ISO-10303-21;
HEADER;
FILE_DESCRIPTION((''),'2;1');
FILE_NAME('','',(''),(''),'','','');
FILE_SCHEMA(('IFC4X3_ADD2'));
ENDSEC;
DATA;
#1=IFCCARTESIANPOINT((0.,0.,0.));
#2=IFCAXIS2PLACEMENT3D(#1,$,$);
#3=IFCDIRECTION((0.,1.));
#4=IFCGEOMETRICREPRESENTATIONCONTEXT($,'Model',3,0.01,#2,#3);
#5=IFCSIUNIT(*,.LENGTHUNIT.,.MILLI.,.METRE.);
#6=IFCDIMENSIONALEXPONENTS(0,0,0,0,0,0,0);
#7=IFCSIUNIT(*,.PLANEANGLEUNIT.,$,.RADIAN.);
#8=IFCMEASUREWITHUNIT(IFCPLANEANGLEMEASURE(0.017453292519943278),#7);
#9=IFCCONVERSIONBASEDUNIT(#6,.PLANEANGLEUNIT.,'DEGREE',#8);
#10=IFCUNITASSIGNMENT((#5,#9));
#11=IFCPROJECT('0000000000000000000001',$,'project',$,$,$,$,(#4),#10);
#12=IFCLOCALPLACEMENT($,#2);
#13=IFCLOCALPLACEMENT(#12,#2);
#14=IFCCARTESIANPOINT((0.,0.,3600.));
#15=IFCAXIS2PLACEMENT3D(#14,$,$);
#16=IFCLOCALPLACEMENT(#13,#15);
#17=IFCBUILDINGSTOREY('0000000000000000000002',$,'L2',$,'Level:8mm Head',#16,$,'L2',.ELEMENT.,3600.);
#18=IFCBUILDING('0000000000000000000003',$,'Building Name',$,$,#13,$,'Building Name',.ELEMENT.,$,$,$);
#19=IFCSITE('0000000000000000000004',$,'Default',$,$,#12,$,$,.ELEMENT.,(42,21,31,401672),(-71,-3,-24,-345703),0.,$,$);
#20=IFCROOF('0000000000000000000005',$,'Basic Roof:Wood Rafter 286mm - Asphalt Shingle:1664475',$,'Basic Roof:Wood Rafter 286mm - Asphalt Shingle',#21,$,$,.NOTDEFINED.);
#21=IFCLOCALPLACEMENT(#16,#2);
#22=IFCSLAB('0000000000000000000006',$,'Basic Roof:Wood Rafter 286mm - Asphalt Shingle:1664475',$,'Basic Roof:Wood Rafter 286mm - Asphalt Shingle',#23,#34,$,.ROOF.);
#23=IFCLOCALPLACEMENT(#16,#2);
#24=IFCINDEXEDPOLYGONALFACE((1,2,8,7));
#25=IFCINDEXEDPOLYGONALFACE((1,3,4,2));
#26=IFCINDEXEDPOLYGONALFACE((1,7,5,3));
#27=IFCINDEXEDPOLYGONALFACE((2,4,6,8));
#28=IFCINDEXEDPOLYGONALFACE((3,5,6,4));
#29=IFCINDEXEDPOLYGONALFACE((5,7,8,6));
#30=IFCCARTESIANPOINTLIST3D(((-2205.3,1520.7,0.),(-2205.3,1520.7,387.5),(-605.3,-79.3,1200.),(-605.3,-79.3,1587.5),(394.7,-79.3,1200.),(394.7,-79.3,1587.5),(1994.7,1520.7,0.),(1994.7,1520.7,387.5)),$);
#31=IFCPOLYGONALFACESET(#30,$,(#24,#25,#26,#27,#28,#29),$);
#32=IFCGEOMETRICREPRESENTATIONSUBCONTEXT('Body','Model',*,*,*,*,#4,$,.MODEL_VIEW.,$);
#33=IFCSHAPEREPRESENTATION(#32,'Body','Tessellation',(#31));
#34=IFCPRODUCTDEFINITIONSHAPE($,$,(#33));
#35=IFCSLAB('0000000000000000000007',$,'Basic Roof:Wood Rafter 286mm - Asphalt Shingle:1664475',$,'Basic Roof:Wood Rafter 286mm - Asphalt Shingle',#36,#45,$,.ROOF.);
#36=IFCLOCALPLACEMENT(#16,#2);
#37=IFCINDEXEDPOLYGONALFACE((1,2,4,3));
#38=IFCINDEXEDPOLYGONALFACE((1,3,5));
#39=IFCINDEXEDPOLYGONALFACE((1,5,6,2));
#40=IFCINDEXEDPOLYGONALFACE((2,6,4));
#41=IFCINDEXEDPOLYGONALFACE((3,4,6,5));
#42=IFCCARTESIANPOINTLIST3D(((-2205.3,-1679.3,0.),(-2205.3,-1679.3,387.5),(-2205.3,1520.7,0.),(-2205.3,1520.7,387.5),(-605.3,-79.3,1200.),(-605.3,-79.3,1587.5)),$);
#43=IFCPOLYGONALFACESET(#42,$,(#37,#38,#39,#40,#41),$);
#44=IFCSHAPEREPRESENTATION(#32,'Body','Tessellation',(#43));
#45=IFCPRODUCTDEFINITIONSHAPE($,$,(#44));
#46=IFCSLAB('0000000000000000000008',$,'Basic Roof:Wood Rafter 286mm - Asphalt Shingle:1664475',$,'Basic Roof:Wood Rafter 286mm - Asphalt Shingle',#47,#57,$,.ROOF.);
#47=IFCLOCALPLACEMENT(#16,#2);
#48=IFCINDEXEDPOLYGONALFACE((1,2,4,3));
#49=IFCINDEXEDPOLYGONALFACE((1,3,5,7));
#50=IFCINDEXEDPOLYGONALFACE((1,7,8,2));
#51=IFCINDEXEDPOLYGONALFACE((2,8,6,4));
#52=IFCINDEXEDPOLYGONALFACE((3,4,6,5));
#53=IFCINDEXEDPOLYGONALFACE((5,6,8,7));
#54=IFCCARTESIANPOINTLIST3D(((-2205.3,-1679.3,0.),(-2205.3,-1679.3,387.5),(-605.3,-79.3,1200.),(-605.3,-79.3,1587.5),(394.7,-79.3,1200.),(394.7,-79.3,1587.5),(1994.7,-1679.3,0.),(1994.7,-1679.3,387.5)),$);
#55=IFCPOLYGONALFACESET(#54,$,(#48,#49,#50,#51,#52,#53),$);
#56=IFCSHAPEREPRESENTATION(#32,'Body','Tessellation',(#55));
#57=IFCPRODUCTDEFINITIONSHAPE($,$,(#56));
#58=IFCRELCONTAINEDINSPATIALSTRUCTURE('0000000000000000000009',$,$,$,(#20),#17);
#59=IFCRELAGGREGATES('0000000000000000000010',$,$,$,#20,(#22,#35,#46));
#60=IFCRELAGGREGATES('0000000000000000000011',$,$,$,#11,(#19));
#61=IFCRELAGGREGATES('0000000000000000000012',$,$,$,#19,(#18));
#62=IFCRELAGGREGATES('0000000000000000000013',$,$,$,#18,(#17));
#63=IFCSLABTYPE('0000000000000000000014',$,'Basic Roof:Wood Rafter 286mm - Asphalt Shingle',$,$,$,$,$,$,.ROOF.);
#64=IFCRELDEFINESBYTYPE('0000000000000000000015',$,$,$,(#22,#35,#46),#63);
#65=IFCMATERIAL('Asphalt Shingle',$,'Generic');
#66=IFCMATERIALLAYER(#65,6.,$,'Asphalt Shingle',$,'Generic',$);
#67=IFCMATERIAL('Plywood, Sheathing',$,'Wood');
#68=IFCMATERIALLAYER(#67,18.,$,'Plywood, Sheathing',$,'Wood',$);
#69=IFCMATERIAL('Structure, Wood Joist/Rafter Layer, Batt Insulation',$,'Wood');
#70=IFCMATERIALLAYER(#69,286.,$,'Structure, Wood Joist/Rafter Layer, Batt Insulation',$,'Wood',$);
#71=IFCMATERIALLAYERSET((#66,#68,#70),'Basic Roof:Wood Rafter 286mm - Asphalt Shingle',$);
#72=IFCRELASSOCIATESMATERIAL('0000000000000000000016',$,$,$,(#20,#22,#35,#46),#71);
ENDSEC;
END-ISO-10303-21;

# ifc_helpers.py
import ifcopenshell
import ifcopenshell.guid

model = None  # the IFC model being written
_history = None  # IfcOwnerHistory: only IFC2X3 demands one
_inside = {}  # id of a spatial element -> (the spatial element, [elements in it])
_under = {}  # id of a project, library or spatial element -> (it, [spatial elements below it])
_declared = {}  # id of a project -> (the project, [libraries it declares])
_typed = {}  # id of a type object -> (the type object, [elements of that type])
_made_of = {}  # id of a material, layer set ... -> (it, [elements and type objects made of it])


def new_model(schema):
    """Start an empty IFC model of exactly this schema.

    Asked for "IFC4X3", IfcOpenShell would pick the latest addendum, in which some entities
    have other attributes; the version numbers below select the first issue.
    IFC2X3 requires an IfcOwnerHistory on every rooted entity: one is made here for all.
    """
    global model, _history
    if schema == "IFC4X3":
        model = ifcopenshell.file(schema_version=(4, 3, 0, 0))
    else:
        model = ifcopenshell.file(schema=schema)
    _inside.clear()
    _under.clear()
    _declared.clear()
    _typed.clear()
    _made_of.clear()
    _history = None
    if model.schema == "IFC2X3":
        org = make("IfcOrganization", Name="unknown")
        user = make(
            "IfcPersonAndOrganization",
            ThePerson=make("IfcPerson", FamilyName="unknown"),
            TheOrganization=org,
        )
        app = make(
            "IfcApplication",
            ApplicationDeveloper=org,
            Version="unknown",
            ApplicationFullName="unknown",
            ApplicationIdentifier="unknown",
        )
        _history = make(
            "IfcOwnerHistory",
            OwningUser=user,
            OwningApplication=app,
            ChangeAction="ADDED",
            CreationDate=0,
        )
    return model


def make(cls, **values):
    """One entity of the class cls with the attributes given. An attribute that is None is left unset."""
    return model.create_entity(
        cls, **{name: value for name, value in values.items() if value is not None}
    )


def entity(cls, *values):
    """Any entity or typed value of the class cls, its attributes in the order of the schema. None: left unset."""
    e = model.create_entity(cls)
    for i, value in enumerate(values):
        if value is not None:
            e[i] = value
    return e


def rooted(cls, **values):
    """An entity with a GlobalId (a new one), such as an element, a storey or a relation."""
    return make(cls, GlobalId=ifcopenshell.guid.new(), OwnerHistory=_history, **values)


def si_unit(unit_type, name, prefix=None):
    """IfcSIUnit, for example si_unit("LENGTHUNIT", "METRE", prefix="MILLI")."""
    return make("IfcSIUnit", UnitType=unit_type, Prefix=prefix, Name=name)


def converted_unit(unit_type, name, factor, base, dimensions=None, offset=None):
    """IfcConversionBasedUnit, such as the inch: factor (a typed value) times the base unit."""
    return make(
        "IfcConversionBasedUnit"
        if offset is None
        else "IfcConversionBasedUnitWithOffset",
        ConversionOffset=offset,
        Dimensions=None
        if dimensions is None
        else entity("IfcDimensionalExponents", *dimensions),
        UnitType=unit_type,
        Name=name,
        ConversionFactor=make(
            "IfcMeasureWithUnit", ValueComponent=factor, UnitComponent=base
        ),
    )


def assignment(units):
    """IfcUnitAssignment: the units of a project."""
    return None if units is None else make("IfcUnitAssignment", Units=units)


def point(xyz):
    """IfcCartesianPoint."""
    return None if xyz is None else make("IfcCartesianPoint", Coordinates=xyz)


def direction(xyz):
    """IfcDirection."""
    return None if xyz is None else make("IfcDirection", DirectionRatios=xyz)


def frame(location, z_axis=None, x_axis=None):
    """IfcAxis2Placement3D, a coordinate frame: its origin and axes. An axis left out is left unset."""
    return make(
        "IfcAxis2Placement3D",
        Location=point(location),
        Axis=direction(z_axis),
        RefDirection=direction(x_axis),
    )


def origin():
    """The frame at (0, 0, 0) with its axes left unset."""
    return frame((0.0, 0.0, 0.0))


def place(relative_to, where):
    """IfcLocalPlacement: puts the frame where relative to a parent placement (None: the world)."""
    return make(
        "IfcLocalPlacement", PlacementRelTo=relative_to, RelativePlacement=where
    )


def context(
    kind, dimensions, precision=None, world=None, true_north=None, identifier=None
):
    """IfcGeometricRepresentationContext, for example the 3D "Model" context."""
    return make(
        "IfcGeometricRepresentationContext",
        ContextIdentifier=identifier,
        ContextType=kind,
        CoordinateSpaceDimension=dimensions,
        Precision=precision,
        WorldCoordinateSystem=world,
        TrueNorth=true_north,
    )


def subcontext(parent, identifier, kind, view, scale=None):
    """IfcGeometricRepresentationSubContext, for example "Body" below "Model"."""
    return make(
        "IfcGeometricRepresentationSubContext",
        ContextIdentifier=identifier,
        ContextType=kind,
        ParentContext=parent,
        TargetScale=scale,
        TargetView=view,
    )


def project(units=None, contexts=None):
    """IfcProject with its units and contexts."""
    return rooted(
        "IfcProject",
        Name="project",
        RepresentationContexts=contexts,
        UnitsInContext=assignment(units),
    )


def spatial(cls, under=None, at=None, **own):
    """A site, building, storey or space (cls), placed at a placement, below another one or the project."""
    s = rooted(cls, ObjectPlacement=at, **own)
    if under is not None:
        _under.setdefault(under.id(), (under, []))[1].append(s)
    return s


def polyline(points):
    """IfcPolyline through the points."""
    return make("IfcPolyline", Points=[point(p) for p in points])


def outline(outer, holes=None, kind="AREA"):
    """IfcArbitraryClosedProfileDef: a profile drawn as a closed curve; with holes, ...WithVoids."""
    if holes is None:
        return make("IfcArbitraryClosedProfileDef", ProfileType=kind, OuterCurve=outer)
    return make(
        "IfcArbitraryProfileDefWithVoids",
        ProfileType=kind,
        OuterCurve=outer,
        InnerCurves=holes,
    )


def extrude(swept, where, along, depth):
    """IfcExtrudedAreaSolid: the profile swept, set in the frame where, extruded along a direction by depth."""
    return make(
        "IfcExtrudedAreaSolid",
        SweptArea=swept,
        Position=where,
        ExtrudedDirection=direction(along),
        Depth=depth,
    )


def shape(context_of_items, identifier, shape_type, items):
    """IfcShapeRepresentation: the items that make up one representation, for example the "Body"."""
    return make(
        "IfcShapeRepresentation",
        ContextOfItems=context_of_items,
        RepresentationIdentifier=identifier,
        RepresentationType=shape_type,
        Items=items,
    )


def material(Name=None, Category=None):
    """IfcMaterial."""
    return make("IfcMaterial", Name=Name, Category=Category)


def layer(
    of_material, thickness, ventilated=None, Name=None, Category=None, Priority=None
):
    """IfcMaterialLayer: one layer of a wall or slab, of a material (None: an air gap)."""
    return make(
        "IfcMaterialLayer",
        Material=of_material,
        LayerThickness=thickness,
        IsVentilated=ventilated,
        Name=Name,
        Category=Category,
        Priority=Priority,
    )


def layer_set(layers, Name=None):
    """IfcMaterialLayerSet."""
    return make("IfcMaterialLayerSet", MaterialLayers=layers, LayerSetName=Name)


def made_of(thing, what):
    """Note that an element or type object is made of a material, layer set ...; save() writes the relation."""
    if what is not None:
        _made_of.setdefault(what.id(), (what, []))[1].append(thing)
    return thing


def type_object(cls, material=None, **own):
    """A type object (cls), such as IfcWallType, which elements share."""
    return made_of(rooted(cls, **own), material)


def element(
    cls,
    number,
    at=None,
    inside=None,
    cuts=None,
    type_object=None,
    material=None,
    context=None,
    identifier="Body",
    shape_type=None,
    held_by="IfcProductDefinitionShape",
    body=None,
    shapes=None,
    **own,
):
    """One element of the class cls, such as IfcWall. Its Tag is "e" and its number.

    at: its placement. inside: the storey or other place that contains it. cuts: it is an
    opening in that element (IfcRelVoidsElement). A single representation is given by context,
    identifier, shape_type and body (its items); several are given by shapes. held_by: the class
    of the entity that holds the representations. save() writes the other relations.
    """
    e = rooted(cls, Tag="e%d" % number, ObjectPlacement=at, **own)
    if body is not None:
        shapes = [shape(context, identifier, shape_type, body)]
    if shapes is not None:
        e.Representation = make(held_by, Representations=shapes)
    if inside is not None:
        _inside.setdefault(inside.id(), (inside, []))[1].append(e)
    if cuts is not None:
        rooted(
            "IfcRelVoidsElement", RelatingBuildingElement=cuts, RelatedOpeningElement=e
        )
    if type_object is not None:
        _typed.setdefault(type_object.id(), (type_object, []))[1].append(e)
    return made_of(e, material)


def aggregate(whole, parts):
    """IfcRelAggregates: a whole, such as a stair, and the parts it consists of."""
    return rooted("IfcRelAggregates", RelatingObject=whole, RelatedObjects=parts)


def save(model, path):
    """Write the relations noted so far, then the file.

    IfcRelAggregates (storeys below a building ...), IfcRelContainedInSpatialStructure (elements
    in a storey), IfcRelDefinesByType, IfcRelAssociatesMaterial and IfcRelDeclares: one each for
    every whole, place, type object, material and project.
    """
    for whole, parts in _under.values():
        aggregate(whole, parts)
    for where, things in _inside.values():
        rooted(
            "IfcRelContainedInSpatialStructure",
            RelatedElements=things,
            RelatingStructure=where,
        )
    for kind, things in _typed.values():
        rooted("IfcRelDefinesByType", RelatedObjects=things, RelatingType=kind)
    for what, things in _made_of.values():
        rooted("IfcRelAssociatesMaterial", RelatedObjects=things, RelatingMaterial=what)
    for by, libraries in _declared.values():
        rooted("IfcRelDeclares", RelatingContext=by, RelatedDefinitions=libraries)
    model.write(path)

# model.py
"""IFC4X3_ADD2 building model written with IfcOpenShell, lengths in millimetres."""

from ifc_helpers import new_model, entity, si_unit, converted_unit, direction, frame, origin, place, context, subcontext, project, spatial, polyline, outline, extrude, material, layer, layer_set, type_object, element, aggregate, save


model = new_model("IFC4X3_ADD2")

# Units and contexts
model_context = context("Model", 3, precision=0.01, world=origin(), true_north=direction((0.0, 1.0)))
body_context = subcontext(model_context, "Body", "Model", "MODEL_VIEW")
ifc_project = project(units=[si_unit("LENGTHUNIT", "METRE", prefix="MILLI"), converted_unit("PLANEANGLEUNIT", "DEGREE", entity("IfcPlaneAngleMeasure", 0.017453292519943278), si_unit("PLANEANGLEUNIT", "RADIAN"), dimensions=[0, 0, 0, 0, 0, 0, 0])], contexts=[model_context])

# Site, building, storey
site_placement = place(None, origin())
site = spatial("IfcSite", under=ifc_project, at=site_placement, Name="Default", CompositionType="ELEMENT", RefLatitude=(42, 21, 31, 401672), RefLongitude=(-71, -3, -24, -345703), RefElevation=0.0)
building_placement = place(site_placement, origin())
building = spatial("IfcBuilding", under=site, at=building_placement, Name="Building Name", LongName="Building Name", CompositionType="ELEMENT")
storey_placement = place(building_placement, frame((0.0, 0.0, 3600.0)))
storey = spatial("IfcBuildingStorey", under=building, at=storey_placement, Name="L2", ObjectType="Level:8mm Head", LongName="L2", CompositionType="ELEMENT", Elevation=3600.0)

# Roof, slabs
ifc_material_1 = material(Name="Asphalt Shingle", Category="Generic")
ifc_layer_1 = layer(ifc_material_1, 6.0, Name="Asphalt Shingle", Category="Generic")
ifc_material_2 = material(Name="Plywood, Sheathing", Category="Wood")
ifc_layer_2 = layer(ifc_material_2, 18.0, Name="Plywood, Sheathing", Category="Wood")
ifc_material_3 = material(Name="Structure, Wood Joist/Rafter Layer, Batt Insulation", Category="Wood")
ifc_layer_3 = layer(ifc_material_3, 286.0, Name="Structure, Wood Joist/Rafter Layer, Batt Insulation", Category="Wood")
ifc_layer_set = layer_set([ifc_layer_1, ifc_layer_2, ifc_layer_3], Name="Basic Roof:Wood Rafter 286mm - Asphalt Shingle")
roof_placement = place(storey_placement, frame((-2205.3, -1679.3, 0.0)))
roof = element("IfcRoof", 1, at=roof_placement, inside=storey, material=ifc_layer_set, Name="Basic Roof:Wood Rafter 286mm - Asphalt Shingle:1664475", ObjectType="Basic Roof:Wood Rafter 286mm - Asphalt Shingle", PredefinedType="NOTDEFINED")
slab_type = type_object("IfcSlabType", Name="Basic Roof:Wood Rafter 286mm - Asphalt Shingle", PredefinedType="ROOF")
slab_1_placement = place(roof_placement, origin())
slab_1 = element("IfcSlab", 2, at=slab_1_placement, type_object=slab_type, material=ifc_layer_set, Name="Basic Roof:Wood Rafter 286mm - Asphalt Shingle:1664475", ObjectType="Basic Roof:Wood Rafter 286mm - Asphalt Shingle", PredefinedType="ROOF", context=body_context, shape_type="SweptSolid", body=[
    extrude(outline(polyline([(2100.0, 1000.0), (-2100.0, 1000.0), (-500.0, -1000.0), (500.0, -1000.0), (2100.0, 1000.0)])), frame((2100.0, 2400.0, 600.0), z_axis=(0.0, 0.6, 0.8), x_axis=(1.0, 0.0, 0.0)), (0.0, -0.6, 0.8), 387.5),
])
slab_2_placement = place(roof_placement, origin())
slab_2 = element("IfcSlab", 3, at=slab_2_placement, type_object=slab_type, material=ifc_layer_set, Name="Basic Roof:Wood Rafter 286mm - Asphalt Shingle:1664475", ObjectType="Basic Roof:Wood Rafter 286mm - Asphalt Shingle", PredefinedType="ROOF", context=body_context, shape_type="SweptSolid", body=[
    extrude(outline(polyline([(-1000.0, 1600.0), (-1000.0, -1600.0), (1000.0, 0.0), (-1000.0, 1600.0)])), frame((800.0, 1600.0, 600.0), z_axis=(-0.6, 0.0, 0.8), x_axis=(0.8, 0.0, 0.6)), (0.6, 0.0, 0.8), 387.5),
])
slab_3_placement = place(roof_placement, origin())
slab_3 = element("IfcSlab", 4, at=slab_3_placement, type_object=slab_type, material=ifc_layer_set, Name="Basic Roof:Wood Rafter 286mm - Asphalt Shingle:1664475", ObjectType="Basic Roof:Wood Rafter 286mm - Asphalt Shingle", PredefinedType="ROOF", context=body_context, shape_type="SweptSolid", body=[
    extrude(outline(polyline([(-2100.0, -1000.0), (2100.0, -1000.0), (500.0, 1000.0), (-500.0, 1000.0), (-2100.0, -1000.0)])), frame((2100.0, 800.0, 600.0), z_axis=(0.0, -0.6, 0.8), x_axis=(1.0, 0.0, 0.0)), (0.0, 0.6, 0.8), 387.5),
])
aggregate(roof, [slab_1, slab_2, slab_3])

save(model, "model.ifc")
